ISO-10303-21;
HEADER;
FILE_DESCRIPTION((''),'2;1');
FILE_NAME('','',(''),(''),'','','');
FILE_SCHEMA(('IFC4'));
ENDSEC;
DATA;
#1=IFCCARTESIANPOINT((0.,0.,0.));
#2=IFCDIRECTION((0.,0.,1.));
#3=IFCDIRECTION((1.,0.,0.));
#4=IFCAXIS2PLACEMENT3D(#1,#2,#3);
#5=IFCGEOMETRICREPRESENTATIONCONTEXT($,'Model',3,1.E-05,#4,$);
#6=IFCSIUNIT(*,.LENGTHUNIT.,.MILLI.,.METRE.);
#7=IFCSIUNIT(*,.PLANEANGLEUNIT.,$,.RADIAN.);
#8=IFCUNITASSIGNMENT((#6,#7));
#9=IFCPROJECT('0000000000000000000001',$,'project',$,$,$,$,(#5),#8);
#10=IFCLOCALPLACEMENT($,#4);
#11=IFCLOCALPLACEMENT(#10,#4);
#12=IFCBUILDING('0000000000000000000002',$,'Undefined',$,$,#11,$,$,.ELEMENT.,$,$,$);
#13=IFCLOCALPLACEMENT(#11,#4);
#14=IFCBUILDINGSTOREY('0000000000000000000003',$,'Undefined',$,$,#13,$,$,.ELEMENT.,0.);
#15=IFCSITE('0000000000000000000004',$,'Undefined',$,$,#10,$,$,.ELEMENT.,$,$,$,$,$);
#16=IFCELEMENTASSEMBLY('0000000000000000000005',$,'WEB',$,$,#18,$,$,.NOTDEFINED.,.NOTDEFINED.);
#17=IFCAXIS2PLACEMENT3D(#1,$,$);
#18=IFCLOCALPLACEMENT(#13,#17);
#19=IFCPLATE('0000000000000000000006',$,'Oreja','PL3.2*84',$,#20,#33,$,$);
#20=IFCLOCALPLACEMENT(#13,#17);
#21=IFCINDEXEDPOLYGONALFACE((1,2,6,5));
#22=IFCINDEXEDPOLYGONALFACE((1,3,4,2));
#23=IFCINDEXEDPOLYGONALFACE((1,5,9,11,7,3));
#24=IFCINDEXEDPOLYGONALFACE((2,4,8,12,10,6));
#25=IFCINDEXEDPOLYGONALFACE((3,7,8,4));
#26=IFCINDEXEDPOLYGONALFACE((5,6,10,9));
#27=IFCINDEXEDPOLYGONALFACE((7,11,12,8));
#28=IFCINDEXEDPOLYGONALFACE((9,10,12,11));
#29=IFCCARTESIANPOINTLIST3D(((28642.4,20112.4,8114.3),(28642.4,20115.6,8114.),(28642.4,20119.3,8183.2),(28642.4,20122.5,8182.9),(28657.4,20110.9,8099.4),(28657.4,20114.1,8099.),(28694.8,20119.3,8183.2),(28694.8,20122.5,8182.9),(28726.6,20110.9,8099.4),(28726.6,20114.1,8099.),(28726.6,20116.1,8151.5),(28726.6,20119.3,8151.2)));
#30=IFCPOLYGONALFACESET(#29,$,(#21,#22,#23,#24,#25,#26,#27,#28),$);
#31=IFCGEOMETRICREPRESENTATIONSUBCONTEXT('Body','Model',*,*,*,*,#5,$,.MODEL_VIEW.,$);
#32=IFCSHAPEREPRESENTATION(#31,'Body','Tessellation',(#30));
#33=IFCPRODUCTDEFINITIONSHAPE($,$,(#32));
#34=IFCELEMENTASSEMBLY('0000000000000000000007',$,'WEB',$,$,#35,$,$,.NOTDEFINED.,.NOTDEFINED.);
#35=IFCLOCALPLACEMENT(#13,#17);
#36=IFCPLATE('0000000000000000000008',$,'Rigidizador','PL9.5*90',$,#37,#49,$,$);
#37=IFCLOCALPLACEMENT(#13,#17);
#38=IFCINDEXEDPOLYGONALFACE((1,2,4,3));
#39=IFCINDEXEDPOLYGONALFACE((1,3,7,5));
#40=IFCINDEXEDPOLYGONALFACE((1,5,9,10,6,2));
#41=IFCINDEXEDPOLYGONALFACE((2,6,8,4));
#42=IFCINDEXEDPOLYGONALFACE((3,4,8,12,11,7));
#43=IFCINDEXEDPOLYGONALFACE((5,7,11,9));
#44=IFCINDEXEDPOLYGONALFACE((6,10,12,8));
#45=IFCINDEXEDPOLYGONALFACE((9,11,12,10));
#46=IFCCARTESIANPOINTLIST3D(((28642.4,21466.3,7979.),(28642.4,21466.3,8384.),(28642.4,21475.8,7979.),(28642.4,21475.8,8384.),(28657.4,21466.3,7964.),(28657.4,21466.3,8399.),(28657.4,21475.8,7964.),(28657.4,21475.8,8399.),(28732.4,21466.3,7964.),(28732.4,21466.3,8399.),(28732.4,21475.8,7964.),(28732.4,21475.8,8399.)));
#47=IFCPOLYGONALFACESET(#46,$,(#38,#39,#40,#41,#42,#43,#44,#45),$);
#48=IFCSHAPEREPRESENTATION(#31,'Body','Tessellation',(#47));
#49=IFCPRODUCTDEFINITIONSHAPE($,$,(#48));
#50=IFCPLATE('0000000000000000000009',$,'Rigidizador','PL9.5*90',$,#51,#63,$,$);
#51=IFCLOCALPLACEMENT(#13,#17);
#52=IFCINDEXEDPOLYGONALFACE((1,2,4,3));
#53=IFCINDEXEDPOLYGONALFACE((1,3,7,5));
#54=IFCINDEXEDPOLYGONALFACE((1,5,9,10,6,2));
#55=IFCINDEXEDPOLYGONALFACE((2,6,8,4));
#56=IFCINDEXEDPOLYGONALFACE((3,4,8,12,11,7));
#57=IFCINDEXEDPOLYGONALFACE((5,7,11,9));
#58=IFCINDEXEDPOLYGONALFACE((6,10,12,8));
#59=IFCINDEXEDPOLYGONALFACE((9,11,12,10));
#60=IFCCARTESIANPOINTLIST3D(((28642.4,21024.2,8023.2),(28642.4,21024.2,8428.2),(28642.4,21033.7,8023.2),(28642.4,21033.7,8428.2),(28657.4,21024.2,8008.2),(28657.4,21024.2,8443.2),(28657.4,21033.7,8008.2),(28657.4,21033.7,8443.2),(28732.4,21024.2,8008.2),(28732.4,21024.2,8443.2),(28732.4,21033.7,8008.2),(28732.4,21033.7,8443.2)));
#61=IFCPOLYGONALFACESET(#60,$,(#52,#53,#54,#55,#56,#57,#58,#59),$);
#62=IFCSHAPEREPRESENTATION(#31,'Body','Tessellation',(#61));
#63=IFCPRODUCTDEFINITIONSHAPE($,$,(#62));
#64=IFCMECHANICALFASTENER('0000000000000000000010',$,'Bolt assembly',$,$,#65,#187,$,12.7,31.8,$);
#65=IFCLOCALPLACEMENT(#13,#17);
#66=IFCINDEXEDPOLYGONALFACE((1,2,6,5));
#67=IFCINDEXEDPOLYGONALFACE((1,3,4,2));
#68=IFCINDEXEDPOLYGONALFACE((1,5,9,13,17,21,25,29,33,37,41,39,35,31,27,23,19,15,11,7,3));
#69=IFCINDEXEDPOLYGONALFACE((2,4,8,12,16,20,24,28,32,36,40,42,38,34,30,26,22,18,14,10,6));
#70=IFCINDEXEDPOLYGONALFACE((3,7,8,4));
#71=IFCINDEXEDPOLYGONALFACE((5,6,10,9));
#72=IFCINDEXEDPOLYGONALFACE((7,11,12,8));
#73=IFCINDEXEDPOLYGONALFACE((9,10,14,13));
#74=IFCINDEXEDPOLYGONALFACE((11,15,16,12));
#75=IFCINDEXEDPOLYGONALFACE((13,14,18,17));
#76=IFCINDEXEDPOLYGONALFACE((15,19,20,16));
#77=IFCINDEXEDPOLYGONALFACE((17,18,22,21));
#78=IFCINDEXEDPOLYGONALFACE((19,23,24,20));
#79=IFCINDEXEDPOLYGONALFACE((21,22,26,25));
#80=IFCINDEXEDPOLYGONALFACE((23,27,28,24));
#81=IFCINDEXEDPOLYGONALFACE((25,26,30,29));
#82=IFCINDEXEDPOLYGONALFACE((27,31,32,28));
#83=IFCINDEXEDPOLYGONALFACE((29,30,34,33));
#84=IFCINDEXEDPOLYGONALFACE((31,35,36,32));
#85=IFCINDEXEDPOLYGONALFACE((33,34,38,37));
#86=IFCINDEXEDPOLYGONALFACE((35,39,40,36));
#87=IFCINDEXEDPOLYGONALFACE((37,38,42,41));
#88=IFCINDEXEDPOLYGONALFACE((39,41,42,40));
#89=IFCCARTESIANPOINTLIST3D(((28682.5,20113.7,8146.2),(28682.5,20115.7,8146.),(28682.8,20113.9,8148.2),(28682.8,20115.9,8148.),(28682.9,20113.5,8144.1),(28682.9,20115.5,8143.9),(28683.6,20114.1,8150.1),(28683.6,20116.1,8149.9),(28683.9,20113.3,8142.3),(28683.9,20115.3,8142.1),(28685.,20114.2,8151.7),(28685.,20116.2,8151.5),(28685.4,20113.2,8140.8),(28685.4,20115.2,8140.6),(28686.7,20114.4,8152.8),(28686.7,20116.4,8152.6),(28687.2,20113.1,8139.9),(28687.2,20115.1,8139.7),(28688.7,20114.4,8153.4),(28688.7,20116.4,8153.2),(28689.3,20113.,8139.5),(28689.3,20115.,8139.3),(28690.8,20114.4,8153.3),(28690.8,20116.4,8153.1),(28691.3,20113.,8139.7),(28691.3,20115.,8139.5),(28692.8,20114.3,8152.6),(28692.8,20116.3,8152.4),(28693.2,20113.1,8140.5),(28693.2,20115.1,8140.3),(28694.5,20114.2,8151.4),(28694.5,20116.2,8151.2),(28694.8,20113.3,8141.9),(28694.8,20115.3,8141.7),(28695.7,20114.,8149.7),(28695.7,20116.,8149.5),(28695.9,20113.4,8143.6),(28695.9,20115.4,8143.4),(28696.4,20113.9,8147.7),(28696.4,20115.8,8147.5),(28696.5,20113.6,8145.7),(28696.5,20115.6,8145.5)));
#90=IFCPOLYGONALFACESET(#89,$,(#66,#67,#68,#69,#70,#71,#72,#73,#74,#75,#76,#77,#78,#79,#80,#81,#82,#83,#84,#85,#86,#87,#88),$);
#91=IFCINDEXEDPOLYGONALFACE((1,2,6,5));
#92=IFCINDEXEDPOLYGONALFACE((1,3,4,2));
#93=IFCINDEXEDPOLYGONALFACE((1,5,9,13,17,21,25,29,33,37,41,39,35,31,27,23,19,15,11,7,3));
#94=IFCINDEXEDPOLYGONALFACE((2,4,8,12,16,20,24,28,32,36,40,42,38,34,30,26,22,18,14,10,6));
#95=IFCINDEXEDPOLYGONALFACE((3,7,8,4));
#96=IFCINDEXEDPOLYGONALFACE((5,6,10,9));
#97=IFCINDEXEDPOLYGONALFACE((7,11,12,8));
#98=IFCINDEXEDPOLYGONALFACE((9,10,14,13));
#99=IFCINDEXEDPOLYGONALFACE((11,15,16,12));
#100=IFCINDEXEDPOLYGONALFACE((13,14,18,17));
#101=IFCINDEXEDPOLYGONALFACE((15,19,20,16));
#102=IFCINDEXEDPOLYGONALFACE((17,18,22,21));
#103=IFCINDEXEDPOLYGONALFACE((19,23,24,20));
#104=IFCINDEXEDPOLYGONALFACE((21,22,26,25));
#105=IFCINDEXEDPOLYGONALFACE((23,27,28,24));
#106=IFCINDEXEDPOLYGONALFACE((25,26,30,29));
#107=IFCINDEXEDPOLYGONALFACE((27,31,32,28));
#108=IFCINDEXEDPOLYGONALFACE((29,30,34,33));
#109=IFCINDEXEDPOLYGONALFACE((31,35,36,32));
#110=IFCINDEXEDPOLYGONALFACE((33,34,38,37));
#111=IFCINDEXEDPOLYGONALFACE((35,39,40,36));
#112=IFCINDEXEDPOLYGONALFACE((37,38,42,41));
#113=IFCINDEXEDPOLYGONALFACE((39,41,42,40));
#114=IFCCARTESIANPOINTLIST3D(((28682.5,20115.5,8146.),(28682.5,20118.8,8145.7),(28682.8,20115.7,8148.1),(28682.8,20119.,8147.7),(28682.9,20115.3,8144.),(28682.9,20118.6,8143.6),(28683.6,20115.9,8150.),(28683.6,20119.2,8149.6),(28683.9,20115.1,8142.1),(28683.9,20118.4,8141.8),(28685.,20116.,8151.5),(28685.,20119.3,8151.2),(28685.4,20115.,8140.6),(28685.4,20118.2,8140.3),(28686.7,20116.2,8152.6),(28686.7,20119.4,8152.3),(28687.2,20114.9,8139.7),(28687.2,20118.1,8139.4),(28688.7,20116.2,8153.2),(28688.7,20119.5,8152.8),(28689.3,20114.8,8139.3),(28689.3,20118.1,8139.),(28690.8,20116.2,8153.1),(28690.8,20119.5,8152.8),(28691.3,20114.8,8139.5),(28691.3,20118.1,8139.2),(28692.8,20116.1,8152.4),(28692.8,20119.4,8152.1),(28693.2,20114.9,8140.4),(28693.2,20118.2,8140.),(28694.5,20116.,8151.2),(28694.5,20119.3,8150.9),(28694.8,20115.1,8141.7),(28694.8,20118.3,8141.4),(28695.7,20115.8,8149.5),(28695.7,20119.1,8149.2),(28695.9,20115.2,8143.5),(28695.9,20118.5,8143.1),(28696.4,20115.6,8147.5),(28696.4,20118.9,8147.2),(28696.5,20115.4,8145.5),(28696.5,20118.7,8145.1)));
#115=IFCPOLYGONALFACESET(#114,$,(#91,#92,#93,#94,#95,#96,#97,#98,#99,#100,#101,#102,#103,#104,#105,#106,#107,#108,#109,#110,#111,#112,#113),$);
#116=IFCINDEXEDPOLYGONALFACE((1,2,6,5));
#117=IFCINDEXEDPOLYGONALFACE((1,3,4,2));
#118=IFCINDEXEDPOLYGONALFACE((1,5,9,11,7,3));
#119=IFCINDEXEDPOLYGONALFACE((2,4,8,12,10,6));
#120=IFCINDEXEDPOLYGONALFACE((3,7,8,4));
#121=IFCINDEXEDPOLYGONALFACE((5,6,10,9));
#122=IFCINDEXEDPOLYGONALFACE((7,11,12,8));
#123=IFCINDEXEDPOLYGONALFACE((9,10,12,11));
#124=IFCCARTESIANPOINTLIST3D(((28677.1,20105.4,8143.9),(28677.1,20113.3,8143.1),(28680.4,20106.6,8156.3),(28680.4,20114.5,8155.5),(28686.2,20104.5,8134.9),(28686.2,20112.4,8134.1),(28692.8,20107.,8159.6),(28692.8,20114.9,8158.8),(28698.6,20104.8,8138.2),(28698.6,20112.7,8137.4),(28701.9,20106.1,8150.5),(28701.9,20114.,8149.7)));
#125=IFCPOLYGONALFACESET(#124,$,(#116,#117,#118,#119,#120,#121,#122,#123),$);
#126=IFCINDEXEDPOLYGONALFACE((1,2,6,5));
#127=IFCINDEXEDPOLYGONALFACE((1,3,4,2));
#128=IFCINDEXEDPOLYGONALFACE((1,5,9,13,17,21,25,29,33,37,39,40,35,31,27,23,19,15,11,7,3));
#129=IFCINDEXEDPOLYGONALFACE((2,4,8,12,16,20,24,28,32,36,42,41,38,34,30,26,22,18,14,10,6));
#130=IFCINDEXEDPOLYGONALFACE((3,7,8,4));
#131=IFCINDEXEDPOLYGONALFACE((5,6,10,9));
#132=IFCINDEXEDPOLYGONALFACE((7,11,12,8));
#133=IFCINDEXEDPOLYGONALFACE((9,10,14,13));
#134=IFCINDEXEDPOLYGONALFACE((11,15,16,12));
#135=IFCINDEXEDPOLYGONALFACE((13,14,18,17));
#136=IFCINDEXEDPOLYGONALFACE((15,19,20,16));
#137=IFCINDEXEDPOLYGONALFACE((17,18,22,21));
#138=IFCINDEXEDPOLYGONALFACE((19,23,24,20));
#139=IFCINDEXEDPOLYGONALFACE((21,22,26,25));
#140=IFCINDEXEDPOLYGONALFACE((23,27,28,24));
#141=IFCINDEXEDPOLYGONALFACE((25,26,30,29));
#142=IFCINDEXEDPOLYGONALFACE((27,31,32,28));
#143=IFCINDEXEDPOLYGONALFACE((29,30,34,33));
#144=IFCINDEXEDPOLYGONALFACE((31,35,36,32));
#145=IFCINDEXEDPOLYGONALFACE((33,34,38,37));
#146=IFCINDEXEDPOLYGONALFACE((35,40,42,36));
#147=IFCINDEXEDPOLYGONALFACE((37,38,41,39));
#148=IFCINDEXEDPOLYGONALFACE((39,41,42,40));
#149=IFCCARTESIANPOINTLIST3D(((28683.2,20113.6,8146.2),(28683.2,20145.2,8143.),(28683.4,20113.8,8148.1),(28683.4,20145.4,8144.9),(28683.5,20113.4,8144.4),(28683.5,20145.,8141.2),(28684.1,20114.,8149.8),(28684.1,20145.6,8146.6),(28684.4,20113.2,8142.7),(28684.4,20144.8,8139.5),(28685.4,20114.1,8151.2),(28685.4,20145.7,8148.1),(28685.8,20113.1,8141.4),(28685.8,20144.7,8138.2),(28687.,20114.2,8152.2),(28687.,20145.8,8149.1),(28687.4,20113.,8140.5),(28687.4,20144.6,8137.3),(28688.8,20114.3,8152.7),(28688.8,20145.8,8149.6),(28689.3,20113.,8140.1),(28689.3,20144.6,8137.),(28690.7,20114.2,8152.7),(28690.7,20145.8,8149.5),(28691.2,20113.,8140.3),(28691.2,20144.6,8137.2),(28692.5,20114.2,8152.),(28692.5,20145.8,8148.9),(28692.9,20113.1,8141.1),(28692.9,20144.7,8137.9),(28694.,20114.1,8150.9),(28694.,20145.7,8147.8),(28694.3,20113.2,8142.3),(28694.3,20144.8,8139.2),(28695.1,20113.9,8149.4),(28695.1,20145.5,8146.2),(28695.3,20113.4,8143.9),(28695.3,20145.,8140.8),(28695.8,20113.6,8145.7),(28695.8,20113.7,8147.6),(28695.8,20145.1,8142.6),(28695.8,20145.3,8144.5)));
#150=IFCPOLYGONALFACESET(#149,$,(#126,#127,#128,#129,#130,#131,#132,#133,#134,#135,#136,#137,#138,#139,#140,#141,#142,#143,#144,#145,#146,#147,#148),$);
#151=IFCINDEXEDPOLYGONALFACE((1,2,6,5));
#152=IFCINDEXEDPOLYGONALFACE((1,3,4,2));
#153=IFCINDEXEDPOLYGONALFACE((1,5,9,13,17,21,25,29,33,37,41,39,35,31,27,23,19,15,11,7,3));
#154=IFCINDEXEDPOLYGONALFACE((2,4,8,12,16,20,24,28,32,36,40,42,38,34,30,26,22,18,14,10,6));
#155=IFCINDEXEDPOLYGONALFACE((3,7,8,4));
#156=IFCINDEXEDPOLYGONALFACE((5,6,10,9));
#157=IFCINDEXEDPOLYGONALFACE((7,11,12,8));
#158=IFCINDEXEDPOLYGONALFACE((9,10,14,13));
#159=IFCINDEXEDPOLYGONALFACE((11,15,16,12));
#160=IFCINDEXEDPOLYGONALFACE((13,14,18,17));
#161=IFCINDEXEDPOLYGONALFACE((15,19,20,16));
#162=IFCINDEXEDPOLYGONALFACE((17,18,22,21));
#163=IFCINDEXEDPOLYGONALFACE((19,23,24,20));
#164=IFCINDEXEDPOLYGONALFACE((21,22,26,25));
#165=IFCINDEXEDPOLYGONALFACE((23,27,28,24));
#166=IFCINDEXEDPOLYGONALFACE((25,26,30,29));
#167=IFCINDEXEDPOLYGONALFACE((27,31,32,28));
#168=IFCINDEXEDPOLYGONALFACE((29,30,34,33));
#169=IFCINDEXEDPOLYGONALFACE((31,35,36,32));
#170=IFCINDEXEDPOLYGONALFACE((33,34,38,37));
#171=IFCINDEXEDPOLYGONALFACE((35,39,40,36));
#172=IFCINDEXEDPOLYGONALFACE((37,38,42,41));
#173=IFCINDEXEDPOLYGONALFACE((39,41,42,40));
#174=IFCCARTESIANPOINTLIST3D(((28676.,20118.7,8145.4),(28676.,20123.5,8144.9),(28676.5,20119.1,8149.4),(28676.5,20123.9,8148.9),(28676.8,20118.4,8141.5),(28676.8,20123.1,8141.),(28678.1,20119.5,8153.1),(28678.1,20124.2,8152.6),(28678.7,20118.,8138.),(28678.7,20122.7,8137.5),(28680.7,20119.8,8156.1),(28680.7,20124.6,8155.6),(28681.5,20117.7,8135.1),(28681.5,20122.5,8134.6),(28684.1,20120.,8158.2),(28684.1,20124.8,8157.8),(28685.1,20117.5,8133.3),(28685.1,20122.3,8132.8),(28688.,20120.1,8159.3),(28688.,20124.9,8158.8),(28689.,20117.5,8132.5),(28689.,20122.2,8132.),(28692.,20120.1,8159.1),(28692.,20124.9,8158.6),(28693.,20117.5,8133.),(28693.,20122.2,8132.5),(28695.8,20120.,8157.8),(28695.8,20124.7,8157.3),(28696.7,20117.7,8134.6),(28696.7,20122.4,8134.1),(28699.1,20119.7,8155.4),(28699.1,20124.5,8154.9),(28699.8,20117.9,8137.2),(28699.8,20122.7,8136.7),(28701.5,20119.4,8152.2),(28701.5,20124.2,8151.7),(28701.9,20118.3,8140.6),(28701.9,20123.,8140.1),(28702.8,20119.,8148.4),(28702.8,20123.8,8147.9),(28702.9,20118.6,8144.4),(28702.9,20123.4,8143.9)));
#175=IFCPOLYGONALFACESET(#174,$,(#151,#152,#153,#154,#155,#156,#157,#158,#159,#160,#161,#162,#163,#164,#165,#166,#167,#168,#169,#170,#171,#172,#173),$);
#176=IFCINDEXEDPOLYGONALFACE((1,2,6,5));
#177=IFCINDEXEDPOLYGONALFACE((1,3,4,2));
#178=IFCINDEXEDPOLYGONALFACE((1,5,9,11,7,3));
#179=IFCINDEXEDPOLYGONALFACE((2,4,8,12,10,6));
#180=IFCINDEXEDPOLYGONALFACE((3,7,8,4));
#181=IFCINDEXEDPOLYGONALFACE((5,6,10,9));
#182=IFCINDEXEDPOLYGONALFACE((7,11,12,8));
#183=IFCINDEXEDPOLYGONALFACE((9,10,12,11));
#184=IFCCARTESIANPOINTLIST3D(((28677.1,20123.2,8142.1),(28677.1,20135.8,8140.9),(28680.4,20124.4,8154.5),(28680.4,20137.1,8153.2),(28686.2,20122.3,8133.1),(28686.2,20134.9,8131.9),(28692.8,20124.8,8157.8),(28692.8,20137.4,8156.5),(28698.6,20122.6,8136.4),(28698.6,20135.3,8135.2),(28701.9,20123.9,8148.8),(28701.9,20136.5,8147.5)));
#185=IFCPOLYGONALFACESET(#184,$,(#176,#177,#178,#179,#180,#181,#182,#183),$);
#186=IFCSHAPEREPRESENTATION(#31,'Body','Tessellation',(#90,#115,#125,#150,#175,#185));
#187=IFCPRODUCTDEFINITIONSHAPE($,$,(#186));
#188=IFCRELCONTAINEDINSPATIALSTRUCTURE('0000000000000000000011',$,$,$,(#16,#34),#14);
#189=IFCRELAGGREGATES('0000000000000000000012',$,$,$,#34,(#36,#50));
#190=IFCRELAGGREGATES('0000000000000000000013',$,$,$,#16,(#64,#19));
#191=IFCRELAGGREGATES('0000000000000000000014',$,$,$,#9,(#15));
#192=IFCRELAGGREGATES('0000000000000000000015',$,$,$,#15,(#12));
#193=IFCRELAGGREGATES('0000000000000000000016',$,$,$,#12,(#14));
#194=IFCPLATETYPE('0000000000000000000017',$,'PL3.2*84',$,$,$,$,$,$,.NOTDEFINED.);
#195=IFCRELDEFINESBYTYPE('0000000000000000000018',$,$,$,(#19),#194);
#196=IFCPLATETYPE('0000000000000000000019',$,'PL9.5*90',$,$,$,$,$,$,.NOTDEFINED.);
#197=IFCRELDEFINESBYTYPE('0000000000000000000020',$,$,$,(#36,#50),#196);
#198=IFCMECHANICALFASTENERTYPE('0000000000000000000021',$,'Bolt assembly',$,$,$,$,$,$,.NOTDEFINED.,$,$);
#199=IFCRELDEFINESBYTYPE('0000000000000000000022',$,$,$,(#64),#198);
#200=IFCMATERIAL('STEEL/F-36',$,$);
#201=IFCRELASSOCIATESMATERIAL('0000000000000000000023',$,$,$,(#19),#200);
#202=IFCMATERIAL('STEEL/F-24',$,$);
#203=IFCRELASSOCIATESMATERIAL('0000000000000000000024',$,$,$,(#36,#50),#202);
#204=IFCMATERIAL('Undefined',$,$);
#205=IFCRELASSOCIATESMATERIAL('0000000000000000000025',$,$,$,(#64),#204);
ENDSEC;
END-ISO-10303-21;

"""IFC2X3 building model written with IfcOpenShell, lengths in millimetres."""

from ifc_helpers import new_model, si_unit, frame, origin_with_axes, origin_2d_with_axis, place, context, subcontext, project, spatial, polyline, circle, outline, extrude, source, transform, mapped, material, type_object, element, aggregate, save


model = new_model("IFC2X3")

# Units and contexts
model_context = context("Model", 3, precision=1e-05, world=origin_with_axes())
body_context = subcontext(model_context, "Body", "Model", "MODEL_VIEW")
ifc_project = project(units=[si_unit("LENGTHUNIT", "METRE", prefix="MILLI"), si_unit("PLANEANGLEUNIT", "RADIAN")], contexts=[model_context])

# Site, building, storey
site_placement = place(None, origin_with_axes())
site = spatial("IfcSite", under=ifc_project, at=site_placement, Name="Undefined", CompositionType="ELEMENT")
building_placement = place(site_placement, origin_with_axes())
building = spatial("IfcBuilding", under=site, at=building_placement, Name="Undefined", CompositionType="ELEMENT")
storey_placement = place(building_placement, origin_with_axes())
storey = spatial("IfcBuildingStorey", under=building, at=storey_placement, Name="Undefined", CompositionType="ELEMENT", Elevation=0.0)

# Element assembly, plate
assembly_1_placement = place(storey_placement, origin_with_axes())
assembly_1 = element("IfcElementAssembly", 1, at=assembly_1_placement, inside=storey, Name="WEB", AssemblyPlace="NOTDEFINED", PredefinedType="NOTDEFINED")
ifc_material_1 = material(Name="STEEL/F-36")
plate_type_1 = type_object("IfcPlateType", Name="PL3.2*84", PredefinedType="NOTDEFINED")
plate_1_placement = place(assembly_1_placement, frame((28642.4, 20112.5, 8099.2), z_axis=(0.0, -0.995037, 0.099504), x_axis=(1.0, 0.0, 0.0)))
plate_1 = element("IfcPlate", 2, at=plate_1_placement, type_object=plate_type_1, material=ifc_material_1, Name="Oreja", Description="PL3.2*84", context=body_context, shape_type="SweptSolid", body=[
    extrude(outline(polyline([(0.0, 15.0), (15.0, 0.0), (84.2, 0.0), (84.2, 52.4), (52.4, 84.2), (0.0, 84.2), (0.0, 15.0)])), frame((0.0, 0.0, -1.6), z_axis=(0.0, 0.0, 1.0), x_axis=(1.0, 0.0, 0.0)), (0.0, 0.0, 1.0), 3.2),
])

# Element assembly, plates
assembly_2_placement = place(storey_placement, origin_with_axes())
assembly_2 = element("IfcElementAssembly", 3, at=assembly_2_placement, inside=storey, Name="WEB", AssemblyPlace="NOTDEFINED", PredefinedType="NOTDEFINED")
ifc_material_2 = material(Name="STEEL/F-24")
plate_type_2 = type_object("IfcPlateType", Name="PL9.5*90", PredefinedType="NOTDEFINED")
plate_2_placement = place(assembly_2_placement, frame((28732.4, 21471.1, 7964.0), z_axis=(0.0, 1.0, 0.0), x_axis=(-1.0, 0.0, 0.0)))
plate_2 = element("IfcPlate", 4, at=plate_2_placement, type_object=plate_type_2, material=ifc_material_2, Name="Rigidizador", Description="PL9.5*90", context=body_context, shape_type="SweptSolid", body=[
    extrude(outline(polyline([(0.0, 0.0), (75.0, 0.0), (90.0, 15.0), (90.0, 420.0), (75.0, 435.0), (0.0, 435.0), (0.0, 0.0)])), frame((0.0, 0.0, -4.7), z_axis=(0.0, 0.0, 1.0), x_axis=(1.0, 0.0, 0.0)), (0.0, 0.0, 1.0), 9.5),
])
plate_3_placement = place(assembly_2_placement, frame((28732.4, 21029.0, 8008.2), z_axis=(0.0, 1.0, 0.0), x_axis=(-1.0, 0.0, 0.0)))
plate_3 = element("IfcPlate", 5, at=plate_3_placement, type_object=plate_type_2, material=ifc_material_2, Name="Rigidizador", Description="PL9.5*90", context=body_context, shape_type="SweptSolid", body=[
    extrude(outline(polyline([(0.0, 0.0), (75.0, 0.0), (90.0, 15.0), (90.0, 420.0), (75.0, 435.0), (0.0, 435.0), (0.0, 0.0)])), frame((0.0, 0.0, -4.7), z_axis=(0.0, 0.0, 1.0), x_axis=(1.0, 0.0, 0.0)), (0.0, 0.0, 1.0), 9.5),
])
aggregate(assembly_2, [plate_2, plate_3])

# Mechanical fastener
ifc_material_3 = material(Name="Undefined")
mechanical_fastener_type = type_object("IfcMechanicalFastenerType", Name="Bolt assembly")
shared_shape_1 = source(origin_with_axes(), body_context, "Body", "SweptSolid", [
    extrude(circle(Radius=7.0, at=origin_2d_with_axis()), frame((0.0, -1.9, 0.0), z_axis=(0.0, 1.0, 0.0), x_axis=(1.0, 0.0, 0.0)), (0.0, 0.0, 1.0), 2.0),
    extrude(circle(Radius=7.0, at=origin_2d_with_axis()), frame((0.0, -0.1, 0.0), z_axis=(0.0, 1.0, 0.0), x_axis=(1.0, 0.0, 0.0)), (0.0, 0.0, 1.0), 3.3),
    extrude(outline(polyline([(11.1, -6.4), (11.1, 6.4), (0.0, 12.8), (-11.1, 6.4), (-11.1, -6.4), (0.0, -12.8), (11.1, -6.4)])), frame((0.0, -9.9, 0.0), z_axis=(0.0, 1.0, 0.0), x_axis=(1.0, 0.0, 0.0)), (0.0, 0.0, 1.0), 7.9),
    extrude(circle(Radius=6.3, at=origin_2d_with_axis()), frame((0.0, -2.0, 0.0), z_axis=(0.0, 1.0, 0.0), x_axis=(1.0, 0.0, 0.0)), (0.0, 0.0, 1.0), 31.8),
    extrude(circle(Radius=13.5, at=origin_2d_with_axis()), frame((0.0, 3.2, 0.0), z_axis=(0.0, 1.0, 0.0), x_axis=(1.0, 0.0, 0.0)), (0.0, 0.0, 1.0), 4.8),
    extrude(outline(polyline([(11.1, -6.4), (11.1, 6.4), (0.0, 12.8), (-11.1, 6.4), (-11.1, -6.4), (0.0, -12.8), (11.1, -6.4)])), frame((0.0, 8.0, 0.0), z_axis=(0.0, 1.0, 0.0), x_axis=(1.0, 0.0, 0.0)), (0.0, 0.0, 1.0), 12.7),
])
mechanical_fastener_1_placement = place(assembly_1_placement, frame((28689.5, 20115.6, 8146.2), z_axis=(-0.707107, 0.07036, 0.703598), x_axis=(0.707107, 0.07036, 0.703598)))
mechanical_fastener_1 = element("IfcMechanicalFastener", 6, at=mechanical_fastener_1_placement, type_object=mechanical_fastener_type, material=ifc_material_3, Name="Bolt assembly", NominalDiameter=12.7, NominalLength=31.8, context=body_context, shape_type="MappedRepresentation", body=[
    mapped(shared_shape_1, transform((0.0, 0.0, 0.0))),
])
aggregate(assembly_1, [mechanical_fastener_1, plate_1])

save(model, "model.ifc")
